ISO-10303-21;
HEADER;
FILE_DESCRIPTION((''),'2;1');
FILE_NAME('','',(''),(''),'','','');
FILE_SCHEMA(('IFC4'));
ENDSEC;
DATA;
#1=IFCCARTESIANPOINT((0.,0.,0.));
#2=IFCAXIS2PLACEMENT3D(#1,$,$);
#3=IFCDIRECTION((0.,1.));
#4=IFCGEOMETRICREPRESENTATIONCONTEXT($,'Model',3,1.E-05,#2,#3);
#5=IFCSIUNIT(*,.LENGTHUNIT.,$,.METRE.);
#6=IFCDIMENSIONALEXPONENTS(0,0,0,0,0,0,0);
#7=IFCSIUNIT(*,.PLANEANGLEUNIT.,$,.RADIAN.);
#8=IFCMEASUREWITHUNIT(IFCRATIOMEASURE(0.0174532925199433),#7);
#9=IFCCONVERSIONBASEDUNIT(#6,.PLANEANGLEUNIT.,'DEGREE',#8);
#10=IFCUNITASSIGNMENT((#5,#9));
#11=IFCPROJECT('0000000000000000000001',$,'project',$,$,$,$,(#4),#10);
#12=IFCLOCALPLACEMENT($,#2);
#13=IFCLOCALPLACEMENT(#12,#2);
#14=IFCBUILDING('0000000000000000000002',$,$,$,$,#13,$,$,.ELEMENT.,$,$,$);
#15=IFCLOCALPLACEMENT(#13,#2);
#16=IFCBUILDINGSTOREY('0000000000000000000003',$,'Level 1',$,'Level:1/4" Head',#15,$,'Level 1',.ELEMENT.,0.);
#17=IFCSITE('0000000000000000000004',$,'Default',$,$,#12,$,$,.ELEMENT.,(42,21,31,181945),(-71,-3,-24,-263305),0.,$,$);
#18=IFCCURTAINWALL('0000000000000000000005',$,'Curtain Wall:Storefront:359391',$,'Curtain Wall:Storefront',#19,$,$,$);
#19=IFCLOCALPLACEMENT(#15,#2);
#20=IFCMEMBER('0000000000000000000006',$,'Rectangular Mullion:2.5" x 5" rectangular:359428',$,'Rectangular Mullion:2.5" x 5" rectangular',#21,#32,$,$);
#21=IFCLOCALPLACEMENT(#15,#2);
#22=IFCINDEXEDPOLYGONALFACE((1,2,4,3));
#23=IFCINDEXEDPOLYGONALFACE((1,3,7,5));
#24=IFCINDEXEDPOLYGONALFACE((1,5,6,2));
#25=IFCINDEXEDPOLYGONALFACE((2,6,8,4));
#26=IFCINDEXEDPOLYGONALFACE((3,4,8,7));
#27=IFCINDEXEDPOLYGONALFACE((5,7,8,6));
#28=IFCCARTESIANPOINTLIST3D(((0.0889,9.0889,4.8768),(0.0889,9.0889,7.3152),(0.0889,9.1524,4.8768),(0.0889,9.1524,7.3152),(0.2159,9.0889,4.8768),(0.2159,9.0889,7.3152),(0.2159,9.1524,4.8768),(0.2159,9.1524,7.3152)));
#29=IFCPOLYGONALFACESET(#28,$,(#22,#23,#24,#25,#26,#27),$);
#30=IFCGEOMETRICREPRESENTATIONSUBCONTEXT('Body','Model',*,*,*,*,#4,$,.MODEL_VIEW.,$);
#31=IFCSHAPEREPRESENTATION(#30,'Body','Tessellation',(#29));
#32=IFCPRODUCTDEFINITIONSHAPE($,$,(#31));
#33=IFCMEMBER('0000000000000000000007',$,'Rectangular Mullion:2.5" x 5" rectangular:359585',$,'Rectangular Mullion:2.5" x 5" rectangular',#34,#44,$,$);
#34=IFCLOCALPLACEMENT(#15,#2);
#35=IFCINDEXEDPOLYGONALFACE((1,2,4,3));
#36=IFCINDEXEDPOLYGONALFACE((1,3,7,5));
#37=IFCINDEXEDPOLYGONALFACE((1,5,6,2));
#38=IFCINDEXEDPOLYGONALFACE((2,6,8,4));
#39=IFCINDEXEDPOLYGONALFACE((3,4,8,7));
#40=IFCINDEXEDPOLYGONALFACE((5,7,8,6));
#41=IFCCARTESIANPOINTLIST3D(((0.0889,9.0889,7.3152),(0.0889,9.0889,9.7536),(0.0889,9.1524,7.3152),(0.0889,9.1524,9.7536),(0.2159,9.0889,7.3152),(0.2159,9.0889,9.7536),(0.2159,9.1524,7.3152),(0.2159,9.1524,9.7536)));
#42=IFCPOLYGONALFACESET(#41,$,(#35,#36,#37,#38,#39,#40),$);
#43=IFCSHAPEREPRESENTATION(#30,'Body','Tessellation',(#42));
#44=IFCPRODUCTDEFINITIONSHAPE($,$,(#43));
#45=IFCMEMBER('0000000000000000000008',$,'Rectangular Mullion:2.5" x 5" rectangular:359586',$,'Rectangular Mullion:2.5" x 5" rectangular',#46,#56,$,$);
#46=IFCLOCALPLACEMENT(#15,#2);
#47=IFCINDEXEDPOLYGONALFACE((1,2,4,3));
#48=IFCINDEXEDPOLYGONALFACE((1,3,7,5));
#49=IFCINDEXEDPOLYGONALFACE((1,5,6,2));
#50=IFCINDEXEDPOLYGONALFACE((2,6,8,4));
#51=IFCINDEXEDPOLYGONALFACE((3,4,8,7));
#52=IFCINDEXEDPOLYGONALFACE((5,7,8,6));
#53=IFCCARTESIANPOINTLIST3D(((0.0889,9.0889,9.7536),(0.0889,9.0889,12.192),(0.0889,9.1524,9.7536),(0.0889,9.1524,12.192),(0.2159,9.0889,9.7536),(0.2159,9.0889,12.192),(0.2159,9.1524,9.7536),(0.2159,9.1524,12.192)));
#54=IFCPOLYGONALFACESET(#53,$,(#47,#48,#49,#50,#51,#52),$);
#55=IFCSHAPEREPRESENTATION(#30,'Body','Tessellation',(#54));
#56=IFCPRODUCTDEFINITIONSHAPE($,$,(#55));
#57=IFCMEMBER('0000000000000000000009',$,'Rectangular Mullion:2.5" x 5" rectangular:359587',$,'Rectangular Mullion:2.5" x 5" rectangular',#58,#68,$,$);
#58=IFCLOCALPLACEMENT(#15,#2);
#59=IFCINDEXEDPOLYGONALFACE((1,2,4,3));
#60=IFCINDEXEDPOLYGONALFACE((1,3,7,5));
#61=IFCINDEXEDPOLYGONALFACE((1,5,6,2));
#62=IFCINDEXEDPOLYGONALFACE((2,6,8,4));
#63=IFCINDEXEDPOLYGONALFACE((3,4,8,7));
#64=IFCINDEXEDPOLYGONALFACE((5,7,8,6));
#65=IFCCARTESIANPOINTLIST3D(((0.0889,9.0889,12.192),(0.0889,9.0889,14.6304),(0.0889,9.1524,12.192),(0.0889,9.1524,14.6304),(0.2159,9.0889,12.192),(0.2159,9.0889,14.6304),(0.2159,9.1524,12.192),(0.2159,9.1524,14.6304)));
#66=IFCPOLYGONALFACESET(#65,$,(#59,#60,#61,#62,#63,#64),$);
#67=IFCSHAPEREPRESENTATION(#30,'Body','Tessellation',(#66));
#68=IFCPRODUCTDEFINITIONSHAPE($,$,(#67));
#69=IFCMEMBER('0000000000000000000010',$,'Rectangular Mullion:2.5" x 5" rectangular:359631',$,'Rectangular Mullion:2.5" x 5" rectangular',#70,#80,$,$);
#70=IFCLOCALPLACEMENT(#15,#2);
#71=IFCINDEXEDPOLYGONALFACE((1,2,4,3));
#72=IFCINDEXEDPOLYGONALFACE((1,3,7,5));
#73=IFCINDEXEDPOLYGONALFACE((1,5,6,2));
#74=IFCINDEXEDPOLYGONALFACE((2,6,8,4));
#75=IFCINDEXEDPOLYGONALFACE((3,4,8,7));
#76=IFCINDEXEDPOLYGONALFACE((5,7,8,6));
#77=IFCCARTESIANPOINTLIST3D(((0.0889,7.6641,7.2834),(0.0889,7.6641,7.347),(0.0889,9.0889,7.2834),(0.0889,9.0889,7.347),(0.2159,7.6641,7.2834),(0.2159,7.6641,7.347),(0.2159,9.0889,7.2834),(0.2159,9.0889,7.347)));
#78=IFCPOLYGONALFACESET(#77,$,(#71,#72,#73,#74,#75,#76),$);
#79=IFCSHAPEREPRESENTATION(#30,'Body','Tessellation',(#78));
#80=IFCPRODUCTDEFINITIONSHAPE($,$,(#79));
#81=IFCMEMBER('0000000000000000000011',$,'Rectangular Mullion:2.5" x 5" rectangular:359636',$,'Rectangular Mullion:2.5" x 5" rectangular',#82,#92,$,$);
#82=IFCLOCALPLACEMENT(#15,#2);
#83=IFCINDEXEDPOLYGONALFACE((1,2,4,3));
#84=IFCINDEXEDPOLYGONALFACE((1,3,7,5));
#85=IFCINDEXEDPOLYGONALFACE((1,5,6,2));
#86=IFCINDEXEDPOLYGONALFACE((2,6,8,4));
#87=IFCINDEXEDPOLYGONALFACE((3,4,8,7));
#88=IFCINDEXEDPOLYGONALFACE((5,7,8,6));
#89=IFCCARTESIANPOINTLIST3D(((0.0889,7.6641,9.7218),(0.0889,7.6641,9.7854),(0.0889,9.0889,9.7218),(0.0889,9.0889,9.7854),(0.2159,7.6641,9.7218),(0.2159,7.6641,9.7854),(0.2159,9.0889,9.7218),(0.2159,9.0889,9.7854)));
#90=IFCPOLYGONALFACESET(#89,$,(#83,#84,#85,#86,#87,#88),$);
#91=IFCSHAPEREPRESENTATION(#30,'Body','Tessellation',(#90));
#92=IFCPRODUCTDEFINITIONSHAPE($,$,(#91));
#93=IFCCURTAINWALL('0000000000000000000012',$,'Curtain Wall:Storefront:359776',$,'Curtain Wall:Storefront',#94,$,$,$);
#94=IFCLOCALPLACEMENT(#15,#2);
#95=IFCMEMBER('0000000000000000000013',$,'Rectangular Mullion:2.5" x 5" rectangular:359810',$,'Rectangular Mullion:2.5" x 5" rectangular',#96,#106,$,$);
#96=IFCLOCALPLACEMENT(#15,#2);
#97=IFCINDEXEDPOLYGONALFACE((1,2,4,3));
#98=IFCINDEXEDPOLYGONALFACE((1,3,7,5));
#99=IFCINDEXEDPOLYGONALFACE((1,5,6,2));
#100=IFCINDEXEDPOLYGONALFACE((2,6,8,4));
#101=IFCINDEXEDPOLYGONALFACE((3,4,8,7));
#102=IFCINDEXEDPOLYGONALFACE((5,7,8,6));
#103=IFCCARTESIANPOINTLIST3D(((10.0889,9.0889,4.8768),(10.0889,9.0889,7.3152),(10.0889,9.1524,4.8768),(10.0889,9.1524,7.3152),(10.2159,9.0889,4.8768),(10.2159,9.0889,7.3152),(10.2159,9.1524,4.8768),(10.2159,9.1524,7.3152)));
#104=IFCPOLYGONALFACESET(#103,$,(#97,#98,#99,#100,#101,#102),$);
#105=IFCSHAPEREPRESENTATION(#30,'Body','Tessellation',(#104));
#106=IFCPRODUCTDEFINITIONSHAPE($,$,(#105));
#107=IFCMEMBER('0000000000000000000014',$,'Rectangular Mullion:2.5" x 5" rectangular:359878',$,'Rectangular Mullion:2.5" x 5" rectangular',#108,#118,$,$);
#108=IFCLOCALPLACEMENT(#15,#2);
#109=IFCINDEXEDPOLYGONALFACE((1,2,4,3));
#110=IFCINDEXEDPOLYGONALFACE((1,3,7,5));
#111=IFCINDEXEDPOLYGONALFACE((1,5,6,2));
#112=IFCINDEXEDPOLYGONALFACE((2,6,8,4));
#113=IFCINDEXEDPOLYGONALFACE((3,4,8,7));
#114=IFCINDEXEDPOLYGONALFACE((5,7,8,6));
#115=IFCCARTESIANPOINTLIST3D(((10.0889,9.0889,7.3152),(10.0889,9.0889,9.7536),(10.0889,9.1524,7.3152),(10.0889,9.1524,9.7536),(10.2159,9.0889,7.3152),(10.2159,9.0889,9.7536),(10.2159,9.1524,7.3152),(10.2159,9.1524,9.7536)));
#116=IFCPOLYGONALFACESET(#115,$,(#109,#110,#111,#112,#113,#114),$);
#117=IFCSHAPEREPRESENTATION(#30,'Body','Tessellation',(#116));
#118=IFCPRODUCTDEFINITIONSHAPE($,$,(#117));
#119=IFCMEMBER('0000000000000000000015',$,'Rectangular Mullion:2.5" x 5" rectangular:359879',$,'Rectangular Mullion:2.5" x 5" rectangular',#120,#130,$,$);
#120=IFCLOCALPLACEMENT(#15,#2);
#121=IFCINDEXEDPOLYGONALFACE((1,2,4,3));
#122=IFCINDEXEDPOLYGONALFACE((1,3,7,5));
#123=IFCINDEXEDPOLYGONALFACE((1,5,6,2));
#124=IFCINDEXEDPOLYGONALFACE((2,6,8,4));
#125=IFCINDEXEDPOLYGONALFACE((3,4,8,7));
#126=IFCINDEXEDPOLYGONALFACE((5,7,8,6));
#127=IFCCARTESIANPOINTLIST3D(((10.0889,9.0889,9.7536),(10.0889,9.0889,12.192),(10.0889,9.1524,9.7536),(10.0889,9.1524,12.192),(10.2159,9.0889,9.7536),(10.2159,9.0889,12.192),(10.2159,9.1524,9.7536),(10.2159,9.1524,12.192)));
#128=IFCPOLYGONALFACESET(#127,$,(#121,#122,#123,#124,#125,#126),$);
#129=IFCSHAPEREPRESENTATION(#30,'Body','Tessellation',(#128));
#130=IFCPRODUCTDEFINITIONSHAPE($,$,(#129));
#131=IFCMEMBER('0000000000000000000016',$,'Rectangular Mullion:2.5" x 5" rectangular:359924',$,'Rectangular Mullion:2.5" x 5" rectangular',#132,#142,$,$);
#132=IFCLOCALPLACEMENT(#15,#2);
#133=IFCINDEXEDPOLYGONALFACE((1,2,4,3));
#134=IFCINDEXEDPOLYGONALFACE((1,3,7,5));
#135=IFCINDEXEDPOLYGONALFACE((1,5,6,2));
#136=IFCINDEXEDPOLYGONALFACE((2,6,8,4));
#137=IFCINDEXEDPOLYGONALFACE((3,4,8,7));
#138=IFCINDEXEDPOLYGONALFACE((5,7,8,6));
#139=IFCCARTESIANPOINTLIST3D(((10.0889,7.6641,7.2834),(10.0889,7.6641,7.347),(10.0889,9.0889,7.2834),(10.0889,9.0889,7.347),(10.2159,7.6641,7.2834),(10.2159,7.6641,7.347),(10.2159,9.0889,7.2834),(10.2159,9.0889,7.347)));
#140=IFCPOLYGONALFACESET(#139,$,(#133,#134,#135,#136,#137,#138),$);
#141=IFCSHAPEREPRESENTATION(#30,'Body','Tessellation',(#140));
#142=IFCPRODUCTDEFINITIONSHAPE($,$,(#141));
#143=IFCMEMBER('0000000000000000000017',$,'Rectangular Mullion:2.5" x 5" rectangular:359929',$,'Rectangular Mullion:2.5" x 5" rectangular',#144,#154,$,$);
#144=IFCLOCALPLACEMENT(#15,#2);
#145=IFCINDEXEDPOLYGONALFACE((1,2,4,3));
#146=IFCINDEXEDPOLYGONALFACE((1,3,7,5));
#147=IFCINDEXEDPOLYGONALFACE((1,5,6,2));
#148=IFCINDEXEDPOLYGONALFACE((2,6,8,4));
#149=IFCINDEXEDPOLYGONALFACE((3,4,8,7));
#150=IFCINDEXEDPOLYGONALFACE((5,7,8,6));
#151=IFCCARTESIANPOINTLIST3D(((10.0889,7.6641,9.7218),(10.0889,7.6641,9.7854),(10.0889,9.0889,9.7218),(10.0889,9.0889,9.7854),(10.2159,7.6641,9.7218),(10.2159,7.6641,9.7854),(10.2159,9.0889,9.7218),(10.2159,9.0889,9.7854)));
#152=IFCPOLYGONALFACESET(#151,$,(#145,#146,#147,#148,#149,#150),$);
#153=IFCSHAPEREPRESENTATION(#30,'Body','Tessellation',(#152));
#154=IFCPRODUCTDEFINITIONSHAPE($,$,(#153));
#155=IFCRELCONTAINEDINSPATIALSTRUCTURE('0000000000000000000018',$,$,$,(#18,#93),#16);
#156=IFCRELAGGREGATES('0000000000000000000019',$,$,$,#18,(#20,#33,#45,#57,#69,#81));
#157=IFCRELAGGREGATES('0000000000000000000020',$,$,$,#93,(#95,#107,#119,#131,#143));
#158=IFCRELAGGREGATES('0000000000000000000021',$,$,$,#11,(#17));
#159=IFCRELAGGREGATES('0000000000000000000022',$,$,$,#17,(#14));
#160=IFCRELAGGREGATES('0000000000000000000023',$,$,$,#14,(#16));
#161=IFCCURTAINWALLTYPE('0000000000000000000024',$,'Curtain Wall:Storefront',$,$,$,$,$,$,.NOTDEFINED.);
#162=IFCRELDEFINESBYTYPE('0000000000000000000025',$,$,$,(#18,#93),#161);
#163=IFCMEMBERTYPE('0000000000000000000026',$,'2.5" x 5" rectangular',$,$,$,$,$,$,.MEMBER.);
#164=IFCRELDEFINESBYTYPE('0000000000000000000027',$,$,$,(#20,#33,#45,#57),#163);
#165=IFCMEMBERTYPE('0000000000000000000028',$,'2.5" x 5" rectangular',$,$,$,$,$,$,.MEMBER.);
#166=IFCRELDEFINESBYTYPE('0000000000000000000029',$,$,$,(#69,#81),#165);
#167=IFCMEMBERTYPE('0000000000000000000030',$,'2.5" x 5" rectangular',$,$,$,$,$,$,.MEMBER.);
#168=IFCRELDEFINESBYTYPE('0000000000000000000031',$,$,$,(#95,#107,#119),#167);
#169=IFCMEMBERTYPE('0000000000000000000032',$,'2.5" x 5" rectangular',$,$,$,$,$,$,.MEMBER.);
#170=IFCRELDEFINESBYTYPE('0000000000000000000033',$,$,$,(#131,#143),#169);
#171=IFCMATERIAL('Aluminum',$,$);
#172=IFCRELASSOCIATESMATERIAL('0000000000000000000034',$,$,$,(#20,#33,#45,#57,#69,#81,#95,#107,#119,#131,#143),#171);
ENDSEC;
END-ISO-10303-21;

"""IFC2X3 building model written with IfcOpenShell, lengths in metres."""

from ifc_helpers import new_model, entity, si_unit, converted_unit, direction, frame, origin, origin_2d_with_axis, place, context, subcontext, project, spatial, rectangle, extrude, source, transform, mapped, material, type_object, type_shapes, element, aggregate, save


model = new_model("IFC2X3")

# Units and contexts
model_context = context("Model", 3, precision=1e-05, world=origin(), true_north=direction((0.0, 1.0)))
body_context = subcontext(model_context, "Body", "Model", "MODEL_VIEW")
ifc_project = project(units=[si_unit("LENGTHUNIT", "METRE"), converted_unit("PLANEANGLEUNIT", "DEGREE", entity("IfcRatioMeasure", 0.0174532925199433), si_unit("PLANEANGLEUNIT", "RADIAN"), dimensions=[0, 0, 0, 0, 0, 0, 0])], contexts=[model_context])

# Site, building, storey
site_placement = place(None, origin())
site = spatial("IfcSite", under=ifc_project, at=site_placement, Name="Default", CompositionType="ELEMENT", RefLatitude=(42, 21, 31, 181945), RefLongitude=(-71, -3, -24, -263305), RefElevation=0.0)
building_placement = place(site_placement, origin())
building = spatial("IfcBuilding", under=site, at=building_placement, CompositionType="ELEMENT")
storey_placement = place(building_placement, origin())
storey = spatial("IfcBuildingStorey", under=building, at=storey_placement, Name="Level 1", ObjectType="Level:1/4\" Head", LongName="Level 1", CompositionType="ELEMENT", Elevation=0.0)

# Curtain walls, members
curtain_wall_type = type_object("IfcCurtainWallType", Name="Curtain Wall:Storefront", PredefinedType="NOTDEFINED")
curtain_wall_1_placement = place(storey_placement, origin())
curtain_wall_1 = element("IfcCurtainWall", 1, at=curtain_wall_1_placement, inside=storey, type_object=curtain_wall_type, Name="Curtain Wall:Storefront:359391", ObjectType="Curtain Wall:Storefront")
ifc_material = material(Name="Aluminum")
member_type_1 = type_object("IfcMemberType", Name="2.5\" x 5\" rectangular", PredefinedType="MEMBER")
shared_shape_1 = source(origin(), body_context, "Body", "SweptSolid", [
    extrude(rectangle(XDim=0.127, YDim=0.0635, at=origin_2d_with_axis()), frame((-0.0318, 0.0, -2.4384), z_axis=(0.0, 0.0, 1.0), x_axis=(0.0, -1.0, 0.0)), (0.0, 0.0, 1.0), 2.4384),
])
type_shapes(member_type_1, [shared_shape_1])
member_1_placement = place(storey_placement, frame((0.1524, 9.1524, 4.8768), z_axis=(0.0, 0.0, -1.0), x_axis=(0.0, 1.0, 0.0)))
member_1 = element("IfcMember", 2, at=member_1_placement, type_object=member_type_1, material=ifc_material, Name="Rectangular Mullion:2.5\" x 5\" rectangular:359428", ObjectType="Rectangular Mullion:2.5\" x 5\" rectangular", context=body_context, shape_type="MappedRepresentation", body=[
    mapped(shared_shape_1, transform((0.0, 0.0, 0.0), scale=1.0)),
])
member_2_placement = place(storey_placement, frame((0.1524, 9.1524, 7.3152), z_axis=(0.0, 0.0, -1.0), x_axis=(0.0, 1.0, 0.0)))
member_2 = element("IfcMember", 3, at=member_2_placement, type_object=member_type_1, material=ifc_material, Name="Rectangular Mullion:2.5\" x 5\" rectangular:359585", ObjectType="Rectangular Mullion:2.5\" x 5\" rectangular", context=body_context, shape_type="MappedRepresentation", body=[
    mapped(shared_shape_1, transform((0.0, 0.0, 0.0), scale=1.0)),
])
member_3_placement = place(storey_placement, frame((0.1524, 9.1524, 9.7536), z_axis=(0.0, 0.0, -1.0), x_axis=(0.0, 1.0, 0.0)))
member_3 = element("IfcMember", 4, at=member_3_placement, type_object=member_type_1, material=ifc_material, Name="Rectangular Mullion:2.5\" x 5\" rectangular:359586", ObjectType="Rectangular Mullion:2.5\" x 5\" rectangular", context=body_context, shape_type="MappedRepresentation", body=[
    mapped(shared_shape_1, transform((0.0, 0.0, 0.0), scale=1.0)),
])
member_4_placement = place(storey_placement, frame((0.1524, 9.1524, 12.192), z_axis=(0.0, 0.0, -1.0), x_axis=(0.0, 1.0, 0.0)))
member_4 = element("IfcMember", 5, at=member_4_placement, type_object=member_type_1, material=ifc_material, Name="Rectangular Mullion:2.5\" x 5\" rectangular:359587", ObjectType="Rectangular Mullion:2.5\" x 5\" rectangular", context=body_context, shape_type="MappedRepresentation", body=[
    mapped(shared_shape_1, transform((0.0, 0.0, 0.0), scale=1.0)),
])
member_type_2 = type_object("IfcMemberType", Name="2.5\" x 5\" rectangular", PredefinedType="MEMBER")
shared_shape_2 = source(origin(), body_context, "Body", "SweptSolid", [
    extrude(rectangle(XDim=0.127, YDim=0.0635, at=origin_2d_with_axis()), frame((0.0, 0.0, -1.4248), z_axis=(0.0, 0.0, 1.0), x_axis=(0.0, -1.0, 0.0)), (0.0, 0.0, 1.0), 1.4248),
])
type_shapes(member_type_2, [shared_shape_2])
member_5_placement = place(storey_placement, frame((0.1524, 9.0889, 7.3152), z_axis=(0.0, 1.0, 0.0), x_axis=(0.0, 0.0, 1.0)))
member_5 = element("IfcMember", 6, at=member_5_placement, type_object=member_type_2, material=ifc_material, Name="Rectangular Mullion:2.5\" x 5\" rectangular:359631", ObjectType="Rectangular Mullion:2.5\" x 5\" rectangular", context=body_context, shape_type="MappedRepresentation", body=[
    mapped(shared_shape_2, transform((0.0, 0.0, 0.0), scale=1.0)),
])
member_6_placement = place(storey_placement, frame((0.1524, 9.0889, 9.7536), z_axis=(0.0, 1.0, 0.0), x_axis=(0.0, 0.0, 1.0)))
member_6 = element("IfcMember", 7, at=member_6_placement, type_object=member_type_2, material=ifc_material, Name="Rectangular Mullion:2.5\" x 5\" rectangular:359636", ObjectType="Rectangular Mullion:2.5\" x 5\" rectangular", context=body_context, shape_type="MappedRepresentation", body=[
    mapped(shared_shape_2, transform((0.0, 0.0, 0.0), scale=1.0)),
])
aggregate(curtain_wall_1, [member_1, member_2, member_3, member_4, member_5, member_6])
curtain_wall_2_placement = place(storey_placement, origin())
curtain_wall_2 = element("IfcCurtainWall", 8, at=curtain_wall_2_placement, inside=storey, type_object=curtain_wall_type, Name="Curtain Wall:Storefront:359776", ObjectType="Curtain Wall:Storefront")
member_type_3 = type_object("IfcMemberType", Name="2.5\" x 5\" rectangular", PredefinedType="MEMBER")
shared_shape_3 = source(origin(), body_context, "Body", "SweptSolid", [
    extrude(rectangle(XDim=0.127, YDim=0.0635, at=origin_2d_with_axis()), frame((-0.0318, 0.0, -2.4384), z_axis=(0.0, 0.0, 1.0), x_axis=(0.0, -1.0, 0.0)), (0.0, 0.0, 1.0), 2.4384),
])
type_shapes(member_type_3, [shared_shape_3])
member_7_placement = place(storey_placement, frame((10.1524, 9.1524, 4.8768), z_axis=(0.0, 0.0, -1.0), x_axis=(0.0, 1.0, 0.0)))
member_7 = element("IfcMember", 9, at=member_7_placement, type_object=member_type_3, material=ifc_material, Name="Rectangular Mullion:2.5\" x 5\" rectangular:359810", ObjectType="Rectangular Mullion:2.5\" x 5\" rectangular", context=body_context, shape_type="MappedRepresentation", body=[
    mapped(shared_shape_3, transform((0.0, 0.0, 0.0), scale=1.0)),
])
member_8_placement = place(storey_placement, frame((10.1524, 9.1524, 7.3152), z_axis=(0.0, 0.0, -1.0), x_axis=(0.0, 1.0, 0.0)))
member_8 = element("IfcMember", 10, at=member_8_placement, type_object=member_type_3, material=ifc_material, Name="Rectangular Mullion:2.5\" x 5\" rectangular:359878", ObjectType="Rectangular Mullion:2.5\" x 5\" rectangular", context=body_context, shape_type="MappedRepresentation", body=[
    mapped(shared_shape_3, transform((0.0, 0.0, 0.0), scale=1.0)),
])
member_9_placement = place(storey_placement, frame((10.1524, 9.1524, 9.7536), z_axis=(0.0, 0.0, -1.0), x_axis=(0.0, 1.0, 0.0)))
member_9 = element("IfcMember", 11, at=member_9_placement, type_object=member_type_3, material=ifc_material, Name="Rectangular Mullion:2.5\" x 5\" rectangular:359879", ObjectType="Rectangular Mullion:2.5\" x 5\" rectangular", context=body_context, shape_type="MappedRepresentation", body=[
    mapped(shared_shape_3, transform((0.0, 0.0, 0.0), scale=1.0)),
])
member_type_4 = type_object("IfcMemberType", Name="2.5\" x 5\" rectangular", PredefinedType="MEMBER")
shared_shape_4 = source(origin(), body_context, "Body", "SweptSolid", [
    extrude(rectangle(XDim=0.127, YDim=0.0635, at=origin_2d_with_axis()), frame((0.0, 0.0, -1.4248), z_axis=(0.0, 0.0, 1.0), x_axis=(0.0, -1.0, 0.0)), (0.0, 0.0, 1.0), 1.4248),
])
type_shapes(member_type_4, [shared_shape_4])
member_10_placement = place(storey_placement, frame((10.1524, 9.0889, 7.3152), z_axis=(0.0, 1.0, 0.0), x_axis=(0.0, 0.0, 1.0)))
member_10 = element("IfcMember", 12, at=member_10_placement, type_object=member_type_4, material=ifc_material, Name="Rectangular Mullion:2.5\" x 5\" rectangular:359924", ObjectType="Rectangular Mullion:2.5\" x 5\" rectangular", context=body_context, shape_type="MappedRepresentation", body=[
    mapped(shared_shape_4, transform((0.0, 0.0, 0.0), scale=1.0)),
])
member_11_placement = place(storey_placement, frame((10.1524, 9.0889, 9.7536), z_axis=(0.0, 1.0, 0.0), x_axis=(0.0, 0.0, 1.0)))
member_11 = element("IfcMember", 13, at=member_11_placement, type_object=member_type_4, material=ifc_material, Name="Rectangular Mullion:2.5\" x 5\" rectangular:359929", ObjectType="Rectangular Mullion:2.5\" x 5\" rectangular", context=body_context, shape_type="MappedRepresentation", body=[
    mapped(shared_shape_4, transform((0.0, 0.0, 0.0), scale=1.0)),
])
aggregate(curtain_wall_2, [member_7, member_8, member_9, member_10, member_11])

save(model, "model.ifc")
